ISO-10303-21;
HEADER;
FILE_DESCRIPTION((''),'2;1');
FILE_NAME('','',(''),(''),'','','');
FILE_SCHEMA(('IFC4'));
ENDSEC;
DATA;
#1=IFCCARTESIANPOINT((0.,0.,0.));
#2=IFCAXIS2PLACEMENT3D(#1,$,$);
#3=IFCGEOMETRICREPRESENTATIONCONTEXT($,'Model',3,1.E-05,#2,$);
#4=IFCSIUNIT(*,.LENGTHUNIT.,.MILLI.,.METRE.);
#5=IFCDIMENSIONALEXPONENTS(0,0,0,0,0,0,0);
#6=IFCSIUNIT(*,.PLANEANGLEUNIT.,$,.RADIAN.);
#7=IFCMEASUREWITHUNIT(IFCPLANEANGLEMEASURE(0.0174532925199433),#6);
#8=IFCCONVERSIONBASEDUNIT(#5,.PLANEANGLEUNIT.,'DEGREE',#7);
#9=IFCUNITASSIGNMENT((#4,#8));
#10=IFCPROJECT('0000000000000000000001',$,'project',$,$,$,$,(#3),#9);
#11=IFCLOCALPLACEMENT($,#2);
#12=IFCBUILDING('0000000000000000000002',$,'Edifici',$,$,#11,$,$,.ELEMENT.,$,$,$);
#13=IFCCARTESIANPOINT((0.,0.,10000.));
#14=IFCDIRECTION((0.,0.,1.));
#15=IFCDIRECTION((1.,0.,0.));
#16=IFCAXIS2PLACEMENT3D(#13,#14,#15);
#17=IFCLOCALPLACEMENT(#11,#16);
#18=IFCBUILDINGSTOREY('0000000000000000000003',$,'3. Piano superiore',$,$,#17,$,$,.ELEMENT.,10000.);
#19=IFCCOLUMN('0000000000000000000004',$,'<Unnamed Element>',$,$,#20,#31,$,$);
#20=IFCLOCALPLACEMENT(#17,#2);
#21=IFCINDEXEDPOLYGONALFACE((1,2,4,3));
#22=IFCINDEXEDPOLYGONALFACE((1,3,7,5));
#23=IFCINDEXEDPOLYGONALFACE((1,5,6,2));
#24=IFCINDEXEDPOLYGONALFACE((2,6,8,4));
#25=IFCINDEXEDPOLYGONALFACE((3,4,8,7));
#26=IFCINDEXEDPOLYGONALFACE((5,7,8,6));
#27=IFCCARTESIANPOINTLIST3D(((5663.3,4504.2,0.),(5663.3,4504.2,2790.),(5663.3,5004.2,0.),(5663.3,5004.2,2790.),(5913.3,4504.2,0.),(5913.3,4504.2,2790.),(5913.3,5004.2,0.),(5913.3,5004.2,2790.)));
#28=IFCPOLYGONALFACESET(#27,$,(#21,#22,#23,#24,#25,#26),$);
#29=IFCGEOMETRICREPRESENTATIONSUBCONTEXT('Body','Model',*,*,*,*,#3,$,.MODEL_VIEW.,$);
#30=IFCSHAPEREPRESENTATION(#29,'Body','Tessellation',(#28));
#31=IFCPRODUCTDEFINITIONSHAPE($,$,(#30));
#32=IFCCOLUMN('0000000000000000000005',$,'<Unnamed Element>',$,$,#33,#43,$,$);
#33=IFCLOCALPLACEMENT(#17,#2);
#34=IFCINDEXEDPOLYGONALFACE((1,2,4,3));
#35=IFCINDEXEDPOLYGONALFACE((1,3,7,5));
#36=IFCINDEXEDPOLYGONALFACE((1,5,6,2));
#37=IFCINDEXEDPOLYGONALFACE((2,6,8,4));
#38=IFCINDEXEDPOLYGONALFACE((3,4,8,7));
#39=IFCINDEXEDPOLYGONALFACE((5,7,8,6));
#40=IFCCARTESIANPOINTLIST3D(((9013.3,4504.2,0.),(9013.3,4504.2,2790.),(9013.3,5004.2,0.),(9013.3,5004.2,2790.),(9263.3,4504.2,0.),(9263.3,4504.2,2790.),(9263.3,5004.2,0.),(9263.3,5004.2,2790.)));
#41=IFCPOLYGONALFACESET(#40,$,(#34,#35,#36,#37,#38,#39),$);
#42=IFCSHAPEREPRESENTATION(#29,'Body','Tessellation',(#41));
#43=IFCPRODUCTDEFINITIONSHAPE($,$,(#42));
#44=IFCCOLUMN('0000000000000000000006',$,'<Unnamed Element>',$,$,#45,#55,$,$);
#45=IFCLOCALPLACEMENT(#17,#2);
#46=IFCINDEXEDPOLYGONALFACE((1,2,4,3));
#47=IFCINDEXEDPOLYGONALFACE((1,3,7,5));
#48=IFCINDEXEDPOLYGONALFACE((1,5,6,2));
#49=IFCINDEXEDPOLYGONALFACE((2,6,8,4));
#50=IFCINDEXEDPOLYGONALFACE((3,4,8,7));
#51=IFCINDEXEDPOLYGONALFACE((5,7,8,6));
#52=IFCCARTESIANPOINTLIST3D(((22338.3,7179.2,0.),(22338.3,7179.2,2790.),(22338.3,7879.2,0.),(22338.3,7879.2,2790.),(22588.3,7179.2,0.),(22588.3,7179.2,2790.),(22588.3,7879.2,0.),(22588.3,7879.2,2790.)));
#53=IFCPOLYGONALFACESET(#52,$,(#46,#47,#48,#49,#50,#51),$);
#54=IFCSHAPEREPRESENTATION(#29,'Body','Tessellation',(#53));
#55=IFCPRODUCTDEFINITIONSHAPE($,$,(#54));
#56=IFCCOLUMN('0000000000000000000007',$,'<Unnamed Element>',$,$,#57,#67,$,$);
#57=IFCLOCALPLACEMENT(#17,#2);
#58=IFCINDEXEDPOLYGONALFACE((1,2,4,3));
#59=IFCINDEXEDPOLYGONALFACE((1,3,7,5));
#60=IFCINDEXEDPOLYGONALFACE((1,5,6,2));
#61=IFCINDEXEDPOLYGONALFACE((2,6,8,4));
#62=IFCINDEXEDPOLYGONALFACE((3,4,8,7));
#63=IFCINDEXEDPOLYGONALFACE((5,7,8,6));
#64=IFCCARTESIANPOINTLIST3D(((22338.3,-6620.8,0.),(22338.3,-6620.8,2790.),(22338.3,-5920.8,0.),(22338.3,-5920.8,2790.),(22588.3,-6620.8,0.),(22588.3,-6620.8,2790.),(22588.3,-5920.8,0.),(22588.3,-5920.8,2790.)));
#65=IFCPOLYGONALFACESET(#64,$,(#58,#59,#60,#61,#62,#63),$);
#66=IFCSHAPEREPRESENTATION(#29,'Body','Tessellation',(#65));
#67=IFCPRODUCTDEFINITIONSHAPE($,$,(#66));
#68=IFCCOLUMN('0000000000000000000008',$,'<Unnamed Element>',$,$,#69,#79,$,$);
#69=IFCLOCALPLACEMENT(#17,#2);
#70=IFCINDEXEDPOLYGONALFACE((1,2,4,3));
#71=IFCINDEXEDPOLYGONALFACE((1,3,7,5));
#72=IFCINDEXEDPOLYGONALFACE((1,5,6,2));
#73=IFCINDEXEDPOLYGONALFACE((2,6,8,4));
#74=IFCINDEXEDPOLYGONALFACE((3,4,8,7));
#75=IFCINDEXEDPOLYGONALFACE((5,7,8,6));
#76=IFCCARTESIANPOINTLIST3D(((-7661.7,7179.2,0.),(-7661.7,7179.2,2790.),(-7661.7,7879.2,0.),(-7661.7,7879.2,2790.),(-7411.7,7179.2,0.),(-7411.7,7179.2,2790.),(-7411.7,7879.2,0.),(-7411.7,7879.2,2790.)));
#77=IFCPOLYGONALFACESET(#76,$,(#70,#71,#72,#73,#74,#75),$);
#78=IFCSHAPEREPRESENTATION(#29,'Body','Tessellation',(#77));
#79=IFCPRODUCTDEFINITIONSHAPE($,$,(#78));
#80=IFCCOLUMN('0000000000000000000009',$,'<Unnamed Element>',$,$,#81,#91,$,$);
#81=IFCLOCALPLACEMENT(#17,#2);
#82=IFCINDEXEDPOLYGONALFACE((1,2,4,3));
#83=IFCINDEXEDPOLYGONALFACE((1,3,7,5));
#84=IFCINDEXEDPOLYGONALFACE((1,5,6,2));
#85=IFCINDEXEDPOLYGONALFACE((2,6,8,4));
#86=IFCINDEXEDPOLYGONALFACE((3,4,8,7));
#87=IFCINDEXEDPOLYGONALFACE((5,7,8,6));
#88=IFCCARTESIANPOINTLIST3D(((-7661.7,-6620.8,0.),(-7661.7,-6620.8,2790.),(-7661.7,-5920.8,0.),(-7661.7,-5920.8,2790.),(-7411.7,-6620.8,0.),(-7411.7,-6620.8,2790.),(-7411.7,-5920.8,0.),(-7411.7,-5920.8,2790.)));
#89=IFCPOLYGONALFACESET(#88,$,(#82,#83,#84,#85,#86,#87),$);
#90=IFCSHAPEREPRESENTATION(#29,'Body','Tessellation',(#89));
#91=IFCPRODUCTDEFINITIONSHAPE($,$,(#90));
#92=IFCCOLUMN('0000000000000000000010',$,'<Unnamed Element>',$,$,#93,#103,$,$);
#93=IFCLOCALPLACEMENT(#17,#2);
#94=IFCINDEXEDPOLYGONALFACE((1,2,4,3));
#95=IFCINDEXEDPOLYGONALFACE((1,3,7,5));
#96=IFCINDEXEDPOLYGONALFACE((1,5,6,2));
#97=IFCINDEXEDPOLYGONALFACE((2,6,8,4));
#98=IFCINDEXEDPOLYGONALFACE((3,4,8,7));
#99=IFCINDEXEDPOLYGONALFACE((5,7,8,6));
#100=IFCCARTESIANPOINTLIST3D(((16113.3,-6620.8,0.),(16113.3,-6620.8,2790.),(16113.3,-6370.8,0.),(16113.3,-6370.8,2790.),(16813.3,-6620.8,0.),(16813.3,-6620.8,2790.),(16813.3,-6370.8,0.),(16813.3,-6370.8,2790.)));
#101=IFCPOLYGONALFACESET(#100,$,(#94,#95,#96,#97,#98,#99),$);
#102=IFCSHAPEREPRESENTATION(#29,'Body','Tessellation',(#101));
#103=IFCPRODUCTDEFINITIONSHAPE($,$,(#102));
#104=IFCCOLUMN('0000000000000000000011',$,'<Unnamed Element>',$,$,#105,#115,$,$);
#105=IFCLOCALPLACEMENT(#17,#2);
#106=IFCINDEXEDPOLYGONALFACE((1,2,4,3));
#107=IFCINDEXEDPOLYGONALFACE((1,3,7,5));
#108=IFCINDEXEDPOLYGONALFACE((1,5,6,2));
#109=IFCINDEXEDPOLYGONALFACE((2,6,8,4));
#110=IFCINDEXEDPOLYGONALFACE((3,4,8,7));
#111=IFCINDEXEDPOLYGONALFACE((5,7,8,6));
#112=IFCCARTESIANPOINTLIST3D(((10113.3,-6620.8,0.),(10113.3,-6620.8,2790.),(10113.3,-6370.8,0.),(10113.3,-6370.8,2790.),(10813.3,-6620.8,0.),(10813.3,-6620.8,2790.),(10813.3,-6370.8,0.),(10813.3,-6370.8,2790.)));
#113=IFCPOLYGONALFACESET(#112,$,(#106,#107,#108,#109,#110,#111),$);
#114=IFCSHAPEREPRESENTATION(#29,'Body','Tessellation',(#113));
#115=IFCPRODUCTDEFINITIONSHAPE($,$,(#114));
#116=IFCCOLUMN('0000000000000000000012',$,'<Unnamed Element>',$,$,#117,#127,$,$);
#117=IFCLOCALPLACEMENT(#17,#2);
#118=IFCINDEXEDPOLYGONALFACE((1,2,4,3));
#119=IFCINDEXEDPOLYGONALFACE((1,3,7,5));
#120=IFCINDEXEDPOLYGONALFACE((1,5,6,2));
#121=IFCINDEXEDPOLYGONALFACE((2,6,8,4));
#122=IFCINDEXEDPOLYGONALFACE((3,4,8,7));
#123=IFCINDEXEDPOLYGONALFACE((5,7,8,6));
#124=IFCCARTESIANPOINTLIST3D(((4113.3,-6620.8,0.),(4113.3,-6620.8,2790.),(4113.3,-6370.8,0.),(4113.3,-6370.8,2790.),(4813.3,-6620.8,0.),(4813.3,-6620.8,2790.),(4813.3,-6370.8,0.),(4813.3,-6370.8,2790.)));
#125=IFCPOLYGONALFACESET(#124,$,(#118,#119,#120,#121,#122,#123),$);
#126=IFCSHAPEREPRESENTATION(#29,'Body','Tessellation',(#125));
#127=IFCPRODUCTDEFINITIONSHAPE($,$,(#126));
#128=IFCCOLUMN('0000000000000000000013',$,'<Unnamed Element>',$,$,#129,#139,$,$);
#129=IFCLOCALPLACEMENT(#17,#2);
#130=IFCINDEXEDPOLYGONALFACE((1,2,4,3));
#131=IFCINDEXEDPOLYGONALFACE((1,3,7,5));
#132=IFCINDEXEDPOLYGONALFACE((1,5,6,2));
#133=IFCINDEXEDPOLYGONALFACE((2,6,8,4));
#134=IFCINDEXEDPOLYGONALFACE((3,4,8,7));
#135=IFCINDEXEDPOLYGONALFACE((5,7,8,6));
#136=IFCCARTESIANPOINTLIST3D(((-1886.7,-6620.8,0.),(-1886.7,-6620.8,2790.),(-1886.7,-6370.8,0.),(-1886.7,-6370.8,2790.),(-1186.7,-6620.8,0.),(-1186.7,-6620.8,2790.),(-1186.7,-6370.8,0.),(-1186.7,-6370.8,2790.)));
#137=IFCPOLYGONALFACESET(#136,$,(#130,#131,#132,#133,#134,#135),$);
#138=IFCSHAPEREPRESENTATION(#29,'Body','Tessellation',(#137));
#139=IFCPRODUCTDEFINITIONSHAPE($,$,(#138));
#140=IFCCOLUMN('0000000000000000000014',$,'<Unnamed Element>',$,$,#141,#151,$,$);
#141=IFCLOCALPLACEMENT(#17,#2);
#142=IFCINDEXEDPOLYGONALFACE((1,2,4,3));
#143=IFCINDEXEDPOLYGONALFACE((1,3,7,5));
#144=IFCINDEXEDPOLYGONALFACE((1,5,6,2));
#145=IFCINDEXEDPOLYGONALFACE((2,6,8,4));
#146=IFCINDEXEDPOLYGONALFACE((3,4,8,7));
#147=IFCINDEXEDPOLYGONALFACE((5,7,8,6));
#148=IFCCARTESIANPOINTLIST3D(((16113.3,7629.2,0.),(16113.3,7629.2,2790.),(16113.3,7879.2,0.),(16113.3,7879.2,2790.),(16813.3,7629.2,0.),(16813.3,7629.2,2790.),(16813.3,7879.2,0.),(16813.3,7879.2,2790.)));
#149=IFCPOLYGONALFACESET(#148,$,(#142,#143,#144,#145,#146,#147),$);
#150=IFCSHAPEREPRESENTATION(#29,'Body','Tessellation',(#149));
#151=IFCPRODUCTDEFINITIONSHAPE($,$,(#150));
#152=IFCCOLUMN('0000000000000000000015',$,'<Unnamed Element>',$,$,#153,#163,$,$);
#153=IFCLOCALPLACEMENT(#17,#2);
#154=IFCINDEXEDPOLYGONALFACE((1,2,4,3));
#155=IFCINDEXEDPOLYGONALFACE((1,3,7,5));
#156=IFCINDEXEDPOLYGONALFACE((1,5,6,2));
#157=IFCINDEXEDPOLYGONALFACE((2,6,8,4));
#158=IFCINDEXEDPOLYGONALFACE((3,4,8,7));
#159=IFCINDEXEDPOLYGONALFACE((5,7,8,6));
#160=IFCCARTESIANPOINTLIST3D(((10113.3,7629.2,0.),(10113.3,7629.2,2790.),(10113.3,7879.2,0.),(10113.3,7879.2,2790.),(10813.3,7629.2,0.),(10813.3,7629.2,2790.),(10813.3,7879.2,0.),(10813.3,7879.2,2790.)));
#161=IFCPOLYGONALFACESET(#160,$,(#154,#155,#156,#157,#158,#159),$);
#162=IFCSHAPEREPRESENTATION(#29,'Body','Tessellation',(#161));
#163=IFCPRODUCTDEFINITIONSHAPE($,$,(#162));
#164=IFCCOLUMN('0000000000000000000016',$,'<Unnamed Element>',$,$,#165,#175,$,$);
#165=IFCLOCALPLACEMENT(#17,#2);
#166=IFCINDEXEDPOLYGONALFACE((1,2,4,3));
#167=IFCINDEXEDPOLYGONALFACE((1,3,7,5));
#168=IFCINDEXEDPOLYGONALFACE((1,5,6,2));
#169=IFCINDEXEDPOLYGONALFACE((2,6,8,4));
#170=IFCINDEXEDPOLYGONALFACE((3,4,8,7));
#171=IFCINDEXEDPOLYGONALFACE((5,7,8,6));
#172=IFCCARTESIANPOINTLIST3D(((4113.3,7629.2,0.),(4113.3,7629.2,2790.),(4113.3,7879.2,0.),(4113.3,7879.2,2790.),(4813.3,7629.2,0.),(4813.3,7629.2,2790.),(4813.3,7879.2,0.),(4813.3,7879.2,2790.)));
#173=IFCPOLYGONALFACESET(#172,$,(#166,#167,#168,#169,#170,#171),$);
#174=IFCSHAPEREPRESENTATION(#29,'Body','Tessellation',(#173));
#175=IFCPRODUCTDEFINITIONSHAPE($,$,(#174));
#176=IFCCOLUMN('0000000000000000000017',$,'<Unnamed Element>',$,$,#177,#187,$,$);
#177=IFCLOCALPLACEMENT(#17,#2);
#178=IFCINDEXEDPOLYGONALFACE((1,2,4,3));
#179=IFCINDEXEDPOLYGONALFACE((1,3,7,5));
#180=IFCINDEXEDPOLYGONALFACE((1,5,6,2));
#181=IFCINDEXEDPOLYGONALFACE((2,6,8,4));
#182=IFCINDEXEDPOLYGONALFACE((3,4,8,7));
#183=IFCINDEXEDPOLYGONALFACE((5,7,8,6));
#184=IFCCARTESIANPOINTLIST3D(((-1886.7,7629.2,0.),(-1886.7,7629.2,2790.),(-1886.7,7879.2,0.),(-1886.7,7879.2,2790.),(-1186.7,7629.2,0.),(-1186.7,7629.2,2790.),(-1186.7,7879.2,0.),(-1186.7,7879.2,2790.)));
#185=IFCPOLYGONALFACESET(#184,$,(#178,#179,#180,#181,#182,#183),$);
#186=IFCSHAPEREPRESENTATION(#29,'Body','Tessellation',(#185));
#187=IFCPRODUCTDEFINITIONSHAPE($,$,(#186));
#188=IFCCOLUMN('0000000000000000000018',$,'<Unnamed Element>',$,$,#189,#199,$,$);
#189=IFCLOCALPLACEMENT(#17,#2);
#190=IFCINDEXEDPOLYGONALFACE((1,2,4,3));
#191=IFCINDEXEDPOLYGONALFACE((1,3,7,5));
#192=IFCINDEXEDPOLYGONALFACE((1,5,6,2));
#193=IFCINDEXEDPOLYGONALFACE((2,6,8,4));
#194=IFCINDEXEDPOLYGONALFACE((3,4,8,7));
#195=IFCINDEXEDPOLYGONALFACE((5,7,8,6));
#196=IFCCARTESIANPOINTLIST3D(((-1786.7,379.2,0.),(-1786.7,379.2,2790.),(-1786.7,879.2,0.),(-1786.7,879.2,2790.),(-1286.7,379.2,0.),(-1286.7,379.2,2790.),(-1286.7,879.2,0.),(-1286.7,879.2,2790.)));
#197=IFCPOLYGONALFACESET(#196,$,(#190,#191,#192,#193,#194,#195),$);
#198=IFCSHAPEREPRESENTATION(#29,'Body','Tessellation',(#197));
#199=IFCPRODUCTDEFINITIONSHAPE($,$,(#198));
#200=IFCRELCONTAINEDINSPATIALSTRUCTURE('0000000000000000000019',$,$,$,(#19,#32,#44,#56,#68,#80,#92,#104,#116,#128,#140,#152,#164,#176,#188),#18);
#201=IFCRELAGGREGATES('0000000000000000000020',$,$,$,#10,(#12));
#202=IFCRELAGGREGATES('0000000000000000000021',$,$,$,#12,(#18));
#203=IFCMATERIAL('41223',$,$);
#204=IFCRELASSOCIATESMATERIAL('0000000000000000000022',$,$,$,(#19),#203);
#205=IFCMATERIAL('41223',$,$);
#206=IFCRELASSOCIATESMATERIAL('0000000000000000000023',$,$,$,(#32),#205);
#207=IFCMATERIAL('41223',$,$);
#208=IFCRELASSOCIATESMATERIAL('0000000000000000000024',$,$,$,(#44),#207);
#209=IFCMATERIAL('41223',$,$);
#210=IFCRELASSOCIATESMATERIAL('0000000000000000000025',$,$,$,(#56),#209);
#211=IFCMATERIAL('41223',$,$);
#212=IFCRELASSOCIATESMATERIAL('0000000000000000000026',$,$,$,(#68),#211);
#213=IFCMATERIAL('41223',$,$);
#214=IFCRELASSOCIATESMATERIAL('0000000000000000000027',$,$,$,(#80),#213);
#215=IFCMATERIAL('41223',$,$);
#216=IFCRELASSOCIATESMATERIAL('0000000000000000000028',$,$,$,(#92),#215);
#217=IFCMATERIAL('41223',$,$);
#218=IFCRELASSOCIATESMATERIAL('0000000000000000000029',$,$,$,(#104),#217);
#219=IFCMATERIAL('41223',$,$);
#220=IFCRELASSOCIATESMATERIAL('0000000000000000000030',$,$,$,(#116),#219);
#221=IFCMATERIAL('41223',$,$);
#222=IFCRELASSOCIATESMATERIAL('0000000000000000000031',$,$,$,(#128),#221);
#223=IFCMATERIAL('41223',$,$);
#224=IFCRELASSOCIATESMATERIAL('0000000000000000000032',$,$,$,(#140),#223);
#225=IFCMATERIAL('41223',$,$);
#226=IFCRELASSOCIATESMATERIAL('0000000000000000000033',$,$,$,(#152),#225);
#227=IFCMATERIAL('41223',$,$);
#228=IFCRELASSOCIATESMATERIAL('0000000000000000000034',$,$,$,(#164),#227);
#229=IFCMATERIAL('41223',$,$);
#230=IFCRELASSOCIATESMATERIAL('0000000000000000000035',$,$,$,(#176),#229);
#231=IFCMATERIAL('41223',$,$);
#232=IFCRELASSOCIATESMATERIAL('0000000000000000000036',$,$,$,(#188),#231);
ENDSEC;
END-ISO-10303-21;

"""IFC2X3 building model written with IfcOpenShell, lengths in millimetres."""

from ifc_helpers import new_model, entity, si_unit, converted_unit, frame, frame_2d, origin, origin_with_axes, place, context, subcontext, project, spatial, rectangle, extrude, material, element, save


model = new_model("IFC2X3")

# Units and contexts
model_context = context("Model", 3, precision=1e-05, world=origin())
body_context = subcontext(model_context, "Body", "Model", "MODEL_VIEW")
ifc_project = project(units=[si_unit("LENGTHUNIT", "METRE", prefix="MILLI"), converted_unit("PLANEANGLEUNIT", "DEGREE", entity("IfcPlaneAngleMeasure", 0.0174532925199433), si_unit("PLANEANGLEUNIT", "RADIAN"), dimensions=[0, 0, 0, 0, 0, 0, 0])], contexts=[model_context])

# Building, storey
building_placement = place(None, origin())
building = spatial("IfcBuilding", under=ifc_project, at=building_placement, Name="Edifici", CompositionType="ELEMENT")
storey_placement = place(building_placement, frame((0.0, 0.0, 10000.0), z_axis=(0.0, 0.0, 1.0), x_axis=(1.0, 0.0, 0.0)))
storey = spatial("IfcBuildingStorey", under=building, at=storey_placement, Name="3. Piano superiore", CompositionType="ELEMENT", Elevation=10000.0)

# Columns
ifc_material_1 = material(Name="41223")
column_1_placement = place(storey_placement, frame((5913.3, 5004.2, 0.0), z_axis=(0.0, 0.0, 1.0), x_axis=(1.0, 0.0, 0.0)))
element("IfcColumn", 1, at=column_1_placement, inside=storey, material=ifc_material_1, Name="<Unnamed Element>", context=body_context, shape_type="SweptSolid", body=[
    extrude(rectangle(XDim=250.0, YDim=500.0, at=frame_2d((-125.0, -250.0), x_axis=(-1.0, 0.0))), origin_with_axes(), (0.0, 0.0, 1.0), 2790.0),
])
ifc_material_2 = material(Name="41223")
column_2_placement = place(storey_placement, frame((9263.3, 5004.2, 0.0), z_axis=(0.0, 0.0, 1.0), x_axis=(1.0, 0.0, 0.0)))
element("IfcColumn", 2, at=column_2_placement, inside=storey, material=ifc_material_2, Name="<Unnamed Element>", context=body_context, shape_type="SweptSolid", body=[
    extrude(rectangle(XDim=250.0, YDim=500.0, at=frame_2d((-125.0, -250.0), x_axis=(-1.0, 0.0))), origin_with_axes(), (0.0, 0.0, 1.0), 2790.0),
])
ifc_material_3 = material(Name="41223")
column_3_placement = place(storey_placement, frame((22588.3, 7879.2, 0.0), z_axis=(0.0, 0.0, 1.0), x_axis=(1.0, 0.0, 0.0)))
element("IfcColumn", 3, at=column_3_placement, inside=storey, material=ifc_material_3, Name="<Unnamed Element>", context=body_context, shape_type="SweptSolid", body=[
    extrude(rectangle(XDim=250.0, YDim=700.0, at=frame_2d((-125.0, -350.0), x_axis=(-1.0, 0.0))), origin_with_axes(), (0.0, 0.0, 1.0), 2790.0),
])
ifc_material_4 = material(Name="41223")
column_4_placement = place(storey_placement, frame((22588.3, -5920.8, 0.0), z_axis=(0.0, 0.0, 1.0), x_axis=(1.0, 0.0, 0.0)))
element("IfcColumn", 4, at=column_4_placement, inside=storey, material=ifc_material_4, Name="<Unnamed Element>", context=body_context, shape_type="SweptSolid", body=[
    extrude(rectangle(XDim=250.0, YDim=700.0, at=frame_2d((-125.0, -350.0), x_axis=(-1.0, 0.0))), origin_with_axes(), (0.0, 0.0, 1.0), 2790.0),
])
ifc_material_5 = material(Name="41223")
column_5_placement = place(storey_placement, frame((-7411.7, 7879.2, 0.0), z_axis=(0.0, 0.0, 1.0), x_axis=(1.0, 0.0, 0.0)))
element("IfcColumn", 5, at=column_5_placement, inside=storey, material=ifc_material_5, Name="<Unnamed Element>", context=body_context, shape_type="SweptSolid", body=[
    extrude(rectangle(XDim=250.0, YDim=700.0, at=frame_2d((-125.0, -350.0), x_axis=(-1.0, 0.0))), origin_with_axes(), (0.0, 0.0, 1.0), 2790.0),
])
ifc_material_6 = material(Name="41223")
column_6_placement = place(storey_placement, frame((-7411.7, -5920.8, 0.0), z_axis=(0.0, 0.0, 1.0), x_axis=(1.0, 0.0, 0.0)))
element("IfcColumn", 6, at=column_6_placement, inside=storey, material=ifc_material_6, Name="<Unnamed Element>", context=body_context, shape_type="SweptSolid", body=[
    extrude(rectangle(XDim=250.0, YDim=700.0, at=frame_2d((-125.0, -350.0), x_axis=(-1.0, 0.0))), origin_with_axes(), (0.0, 0.0, 1.0), 2790.0),
])
ifc_material_7 = material(Name="41223")
column_7_placement = place(storey_placement, frame((16813.3, -6620.8, 0.0), z_axis=(0.0, 0.0, 1.0), x_axis=(1.0, 0.0, 0.0)))
element("IfcColumn", 7, at=column_7_placement, inside=storey, material=ifc_material_7, Name="<Unnamed Element>", context=body_context, shape_type="SweptSolid", body=[
    extrude(rectangle(XDim=250.0, YDim=700.0, at=frame_2d((-350.0, 125.0), x_axis=(0.0, 1.0))), origin_with_axes(), (0.0, 0.0, 1.0), 2790.0),
])
ifc_material_8 = material(Name="41223")
column_8_placement = place(storey_placement, frame((10813.3, -6620.8, 0.0), z_axis=(0.0, 0.0, 1.0), x_axis=(1.0, 0.0, 0.0)))
element("IfcColumn", 8, at=column_8_placement, inside=storey, material=ifc_material_8, Name="<Unnamed Element>", context=body_context, shape_type="SweptSolid", body=[
    extrude(rectangle(XDim=250.0, YDim=700.0, at=frame_2d((-350.0, 125.0), x_axis=(0.0, 1.0))), origin_with_axes(), (0.0, 0.0, 1.0), 2790.0),
])
ifc_material_9 = material(Name="41223")
column_9_placement = place(storey_placement, frame((4813.3, -6620.8, 0.0), z_axis=(0.0, 0.0, 1.0), x_axis=(1.0, 0.0, 0.0)))
element("IfcColumn", 9, at=column_9_placement, inside=storey, material=ifc_material_9, Name="<Unnamed Element>", context=body_context, shape_type="SweptSolid", body=[
    extrude(rectangle(XDim=250.0, YDim=700.0, at=frame_2d((-350.0, 125.0), x_axis=(0.0, 1.0))), origin_with_axes(), (0.0, 0.0, 1.0), 2790.0),
])
ifc_material_10 = material(Name="41223")
column_10_placement = place(storey_placement, frame((-1186.7, -6620.8, 0.0), z_axis=(0.0, 0.0, 1.0), x_axis=(1.0, 0.0, 0.0)))
element("IfcColumn", 10, at=column_10_placement, inside=storey, material=ifc_material_10, Name="<Unnamed Element>", context=body_context, shape_type="SweptSolid", body=[
    extrude(rectangle(XDim=250.0, YDim=700.0, at=frame_2d((-350.0, 125.0), x_axis=(0.0, 1.0))), origin_with_axes(), (0.0, 0.0, 1.0), 2790.0),
])
ifc_material_11 = material(Name="41223")
column_11_placement = place(storey_placement, frame((16813.3, 7629.2, 0.0), z_axis=(0.0, 0.0, 1.0), x_axis=(1.0, 0.0, 0.0)))
element("IfcColumn", 11, at=column_11_placement, inside=storey, material=ifc_material_11, Name="<Unnamed Element>", context=body_context, shape_type="SweptSolid", body=[
    extrude(rectangle(XDim=250.0, YDim=700.0, at=frame_2d((-350.0, 125.0), x_axis=(0.0, 1.0))), origin_with_axes(), (0.0, 0.0, 1.0), 2790.0),
])
ifc_material_12 = material(Name="41223")
column_12_placement = place(storey_placement, frame((10813.3, 7629.2, 0.0), z_axis=(0.0, 0.0, 1.0), x_axis=(1.0, 0.0, 0.0)))
element("IfcColumn", 12, at=column_12_placement, inside=storey, material=ifc_material_12, Name="<Unnamed Element>", context=body_context, shape_type="SweptSolid", body=[
    extrude(rectangle(XDim=250.0, YDim=700.0, at=frame_2d((-350.0, 125.0), x_axis=(0.0, 1.0))), origin_with_axes(), (0.0, 0.0, 1.0), 2790.0),
])
ifc_material_13 = material(Name="41223")
column_13_placement = place(storey_placement, frame((4813.3, 7629.2, 0.0), z_axis=(0.0, 0.0, 1.0), x_axis=(1.0, 0.0, 0.0)))
element("IfcColumn", 13, at=column_13_placement, inside=storey, material=ifc_material_13, Name="<Unnamed Element>", context=body_context, shape_type="SweptSolid", body=[
    extrude(rectangle(XDim=250.0, YDim=700.0, at=frame_2d((-350.0, 125.0), x_axis=(0.0, 1.0))), origin_with_axes(), (0.0, 0.0, 1.0), 2790.0),
])
ifc_material_14 = material(Name="41223")
column_14_placement = place(storey_placement, frame((-1186.7, 7629.2, 0.0), z_axis=(0.0, 0.0, 1.0), x_axis=(1.0, 0.0, 0.0)))
element("IfcColumn", 14, at=column_14_placement, inside=storey, material=ifc_material_14, Name="<Unnamed Element>", context=body_context, shape_type="SweptSolid", body=[
    extrude(rectangle(XDim=250.0, YDim=700.0, at=frame_2d((-350.0, 125.0), x_axis=(0.0, 1.0))), origin_with_axes(), (0.0, 0.0, 1.0), 2790.0),
])
ifc_material_15 = material(Name="41223")
column_15_placement = place(storey_placement, frame((-1786.7, 379.2, 0.0), z_axis=(0.0, 0.0, 1.0), x_axis=(1.0, 0.0, 0.0)))
element("IfcColumn", 15, at=column_15_placement, inside=storey, material=ifc_material_15, Name="<Unnamed Element>", context=body_context, shape_type="SweptSolid", body=[
    extrude(rectangle(XDim=500.0, YDim=500.0, at=frame_2d((250.0, 250.0), x_axis=(1.0, 0.0))), origin_with_axes(), (0.0, 0.0, 1.0), 2790.0),
])

save(model, "model.ifc")
